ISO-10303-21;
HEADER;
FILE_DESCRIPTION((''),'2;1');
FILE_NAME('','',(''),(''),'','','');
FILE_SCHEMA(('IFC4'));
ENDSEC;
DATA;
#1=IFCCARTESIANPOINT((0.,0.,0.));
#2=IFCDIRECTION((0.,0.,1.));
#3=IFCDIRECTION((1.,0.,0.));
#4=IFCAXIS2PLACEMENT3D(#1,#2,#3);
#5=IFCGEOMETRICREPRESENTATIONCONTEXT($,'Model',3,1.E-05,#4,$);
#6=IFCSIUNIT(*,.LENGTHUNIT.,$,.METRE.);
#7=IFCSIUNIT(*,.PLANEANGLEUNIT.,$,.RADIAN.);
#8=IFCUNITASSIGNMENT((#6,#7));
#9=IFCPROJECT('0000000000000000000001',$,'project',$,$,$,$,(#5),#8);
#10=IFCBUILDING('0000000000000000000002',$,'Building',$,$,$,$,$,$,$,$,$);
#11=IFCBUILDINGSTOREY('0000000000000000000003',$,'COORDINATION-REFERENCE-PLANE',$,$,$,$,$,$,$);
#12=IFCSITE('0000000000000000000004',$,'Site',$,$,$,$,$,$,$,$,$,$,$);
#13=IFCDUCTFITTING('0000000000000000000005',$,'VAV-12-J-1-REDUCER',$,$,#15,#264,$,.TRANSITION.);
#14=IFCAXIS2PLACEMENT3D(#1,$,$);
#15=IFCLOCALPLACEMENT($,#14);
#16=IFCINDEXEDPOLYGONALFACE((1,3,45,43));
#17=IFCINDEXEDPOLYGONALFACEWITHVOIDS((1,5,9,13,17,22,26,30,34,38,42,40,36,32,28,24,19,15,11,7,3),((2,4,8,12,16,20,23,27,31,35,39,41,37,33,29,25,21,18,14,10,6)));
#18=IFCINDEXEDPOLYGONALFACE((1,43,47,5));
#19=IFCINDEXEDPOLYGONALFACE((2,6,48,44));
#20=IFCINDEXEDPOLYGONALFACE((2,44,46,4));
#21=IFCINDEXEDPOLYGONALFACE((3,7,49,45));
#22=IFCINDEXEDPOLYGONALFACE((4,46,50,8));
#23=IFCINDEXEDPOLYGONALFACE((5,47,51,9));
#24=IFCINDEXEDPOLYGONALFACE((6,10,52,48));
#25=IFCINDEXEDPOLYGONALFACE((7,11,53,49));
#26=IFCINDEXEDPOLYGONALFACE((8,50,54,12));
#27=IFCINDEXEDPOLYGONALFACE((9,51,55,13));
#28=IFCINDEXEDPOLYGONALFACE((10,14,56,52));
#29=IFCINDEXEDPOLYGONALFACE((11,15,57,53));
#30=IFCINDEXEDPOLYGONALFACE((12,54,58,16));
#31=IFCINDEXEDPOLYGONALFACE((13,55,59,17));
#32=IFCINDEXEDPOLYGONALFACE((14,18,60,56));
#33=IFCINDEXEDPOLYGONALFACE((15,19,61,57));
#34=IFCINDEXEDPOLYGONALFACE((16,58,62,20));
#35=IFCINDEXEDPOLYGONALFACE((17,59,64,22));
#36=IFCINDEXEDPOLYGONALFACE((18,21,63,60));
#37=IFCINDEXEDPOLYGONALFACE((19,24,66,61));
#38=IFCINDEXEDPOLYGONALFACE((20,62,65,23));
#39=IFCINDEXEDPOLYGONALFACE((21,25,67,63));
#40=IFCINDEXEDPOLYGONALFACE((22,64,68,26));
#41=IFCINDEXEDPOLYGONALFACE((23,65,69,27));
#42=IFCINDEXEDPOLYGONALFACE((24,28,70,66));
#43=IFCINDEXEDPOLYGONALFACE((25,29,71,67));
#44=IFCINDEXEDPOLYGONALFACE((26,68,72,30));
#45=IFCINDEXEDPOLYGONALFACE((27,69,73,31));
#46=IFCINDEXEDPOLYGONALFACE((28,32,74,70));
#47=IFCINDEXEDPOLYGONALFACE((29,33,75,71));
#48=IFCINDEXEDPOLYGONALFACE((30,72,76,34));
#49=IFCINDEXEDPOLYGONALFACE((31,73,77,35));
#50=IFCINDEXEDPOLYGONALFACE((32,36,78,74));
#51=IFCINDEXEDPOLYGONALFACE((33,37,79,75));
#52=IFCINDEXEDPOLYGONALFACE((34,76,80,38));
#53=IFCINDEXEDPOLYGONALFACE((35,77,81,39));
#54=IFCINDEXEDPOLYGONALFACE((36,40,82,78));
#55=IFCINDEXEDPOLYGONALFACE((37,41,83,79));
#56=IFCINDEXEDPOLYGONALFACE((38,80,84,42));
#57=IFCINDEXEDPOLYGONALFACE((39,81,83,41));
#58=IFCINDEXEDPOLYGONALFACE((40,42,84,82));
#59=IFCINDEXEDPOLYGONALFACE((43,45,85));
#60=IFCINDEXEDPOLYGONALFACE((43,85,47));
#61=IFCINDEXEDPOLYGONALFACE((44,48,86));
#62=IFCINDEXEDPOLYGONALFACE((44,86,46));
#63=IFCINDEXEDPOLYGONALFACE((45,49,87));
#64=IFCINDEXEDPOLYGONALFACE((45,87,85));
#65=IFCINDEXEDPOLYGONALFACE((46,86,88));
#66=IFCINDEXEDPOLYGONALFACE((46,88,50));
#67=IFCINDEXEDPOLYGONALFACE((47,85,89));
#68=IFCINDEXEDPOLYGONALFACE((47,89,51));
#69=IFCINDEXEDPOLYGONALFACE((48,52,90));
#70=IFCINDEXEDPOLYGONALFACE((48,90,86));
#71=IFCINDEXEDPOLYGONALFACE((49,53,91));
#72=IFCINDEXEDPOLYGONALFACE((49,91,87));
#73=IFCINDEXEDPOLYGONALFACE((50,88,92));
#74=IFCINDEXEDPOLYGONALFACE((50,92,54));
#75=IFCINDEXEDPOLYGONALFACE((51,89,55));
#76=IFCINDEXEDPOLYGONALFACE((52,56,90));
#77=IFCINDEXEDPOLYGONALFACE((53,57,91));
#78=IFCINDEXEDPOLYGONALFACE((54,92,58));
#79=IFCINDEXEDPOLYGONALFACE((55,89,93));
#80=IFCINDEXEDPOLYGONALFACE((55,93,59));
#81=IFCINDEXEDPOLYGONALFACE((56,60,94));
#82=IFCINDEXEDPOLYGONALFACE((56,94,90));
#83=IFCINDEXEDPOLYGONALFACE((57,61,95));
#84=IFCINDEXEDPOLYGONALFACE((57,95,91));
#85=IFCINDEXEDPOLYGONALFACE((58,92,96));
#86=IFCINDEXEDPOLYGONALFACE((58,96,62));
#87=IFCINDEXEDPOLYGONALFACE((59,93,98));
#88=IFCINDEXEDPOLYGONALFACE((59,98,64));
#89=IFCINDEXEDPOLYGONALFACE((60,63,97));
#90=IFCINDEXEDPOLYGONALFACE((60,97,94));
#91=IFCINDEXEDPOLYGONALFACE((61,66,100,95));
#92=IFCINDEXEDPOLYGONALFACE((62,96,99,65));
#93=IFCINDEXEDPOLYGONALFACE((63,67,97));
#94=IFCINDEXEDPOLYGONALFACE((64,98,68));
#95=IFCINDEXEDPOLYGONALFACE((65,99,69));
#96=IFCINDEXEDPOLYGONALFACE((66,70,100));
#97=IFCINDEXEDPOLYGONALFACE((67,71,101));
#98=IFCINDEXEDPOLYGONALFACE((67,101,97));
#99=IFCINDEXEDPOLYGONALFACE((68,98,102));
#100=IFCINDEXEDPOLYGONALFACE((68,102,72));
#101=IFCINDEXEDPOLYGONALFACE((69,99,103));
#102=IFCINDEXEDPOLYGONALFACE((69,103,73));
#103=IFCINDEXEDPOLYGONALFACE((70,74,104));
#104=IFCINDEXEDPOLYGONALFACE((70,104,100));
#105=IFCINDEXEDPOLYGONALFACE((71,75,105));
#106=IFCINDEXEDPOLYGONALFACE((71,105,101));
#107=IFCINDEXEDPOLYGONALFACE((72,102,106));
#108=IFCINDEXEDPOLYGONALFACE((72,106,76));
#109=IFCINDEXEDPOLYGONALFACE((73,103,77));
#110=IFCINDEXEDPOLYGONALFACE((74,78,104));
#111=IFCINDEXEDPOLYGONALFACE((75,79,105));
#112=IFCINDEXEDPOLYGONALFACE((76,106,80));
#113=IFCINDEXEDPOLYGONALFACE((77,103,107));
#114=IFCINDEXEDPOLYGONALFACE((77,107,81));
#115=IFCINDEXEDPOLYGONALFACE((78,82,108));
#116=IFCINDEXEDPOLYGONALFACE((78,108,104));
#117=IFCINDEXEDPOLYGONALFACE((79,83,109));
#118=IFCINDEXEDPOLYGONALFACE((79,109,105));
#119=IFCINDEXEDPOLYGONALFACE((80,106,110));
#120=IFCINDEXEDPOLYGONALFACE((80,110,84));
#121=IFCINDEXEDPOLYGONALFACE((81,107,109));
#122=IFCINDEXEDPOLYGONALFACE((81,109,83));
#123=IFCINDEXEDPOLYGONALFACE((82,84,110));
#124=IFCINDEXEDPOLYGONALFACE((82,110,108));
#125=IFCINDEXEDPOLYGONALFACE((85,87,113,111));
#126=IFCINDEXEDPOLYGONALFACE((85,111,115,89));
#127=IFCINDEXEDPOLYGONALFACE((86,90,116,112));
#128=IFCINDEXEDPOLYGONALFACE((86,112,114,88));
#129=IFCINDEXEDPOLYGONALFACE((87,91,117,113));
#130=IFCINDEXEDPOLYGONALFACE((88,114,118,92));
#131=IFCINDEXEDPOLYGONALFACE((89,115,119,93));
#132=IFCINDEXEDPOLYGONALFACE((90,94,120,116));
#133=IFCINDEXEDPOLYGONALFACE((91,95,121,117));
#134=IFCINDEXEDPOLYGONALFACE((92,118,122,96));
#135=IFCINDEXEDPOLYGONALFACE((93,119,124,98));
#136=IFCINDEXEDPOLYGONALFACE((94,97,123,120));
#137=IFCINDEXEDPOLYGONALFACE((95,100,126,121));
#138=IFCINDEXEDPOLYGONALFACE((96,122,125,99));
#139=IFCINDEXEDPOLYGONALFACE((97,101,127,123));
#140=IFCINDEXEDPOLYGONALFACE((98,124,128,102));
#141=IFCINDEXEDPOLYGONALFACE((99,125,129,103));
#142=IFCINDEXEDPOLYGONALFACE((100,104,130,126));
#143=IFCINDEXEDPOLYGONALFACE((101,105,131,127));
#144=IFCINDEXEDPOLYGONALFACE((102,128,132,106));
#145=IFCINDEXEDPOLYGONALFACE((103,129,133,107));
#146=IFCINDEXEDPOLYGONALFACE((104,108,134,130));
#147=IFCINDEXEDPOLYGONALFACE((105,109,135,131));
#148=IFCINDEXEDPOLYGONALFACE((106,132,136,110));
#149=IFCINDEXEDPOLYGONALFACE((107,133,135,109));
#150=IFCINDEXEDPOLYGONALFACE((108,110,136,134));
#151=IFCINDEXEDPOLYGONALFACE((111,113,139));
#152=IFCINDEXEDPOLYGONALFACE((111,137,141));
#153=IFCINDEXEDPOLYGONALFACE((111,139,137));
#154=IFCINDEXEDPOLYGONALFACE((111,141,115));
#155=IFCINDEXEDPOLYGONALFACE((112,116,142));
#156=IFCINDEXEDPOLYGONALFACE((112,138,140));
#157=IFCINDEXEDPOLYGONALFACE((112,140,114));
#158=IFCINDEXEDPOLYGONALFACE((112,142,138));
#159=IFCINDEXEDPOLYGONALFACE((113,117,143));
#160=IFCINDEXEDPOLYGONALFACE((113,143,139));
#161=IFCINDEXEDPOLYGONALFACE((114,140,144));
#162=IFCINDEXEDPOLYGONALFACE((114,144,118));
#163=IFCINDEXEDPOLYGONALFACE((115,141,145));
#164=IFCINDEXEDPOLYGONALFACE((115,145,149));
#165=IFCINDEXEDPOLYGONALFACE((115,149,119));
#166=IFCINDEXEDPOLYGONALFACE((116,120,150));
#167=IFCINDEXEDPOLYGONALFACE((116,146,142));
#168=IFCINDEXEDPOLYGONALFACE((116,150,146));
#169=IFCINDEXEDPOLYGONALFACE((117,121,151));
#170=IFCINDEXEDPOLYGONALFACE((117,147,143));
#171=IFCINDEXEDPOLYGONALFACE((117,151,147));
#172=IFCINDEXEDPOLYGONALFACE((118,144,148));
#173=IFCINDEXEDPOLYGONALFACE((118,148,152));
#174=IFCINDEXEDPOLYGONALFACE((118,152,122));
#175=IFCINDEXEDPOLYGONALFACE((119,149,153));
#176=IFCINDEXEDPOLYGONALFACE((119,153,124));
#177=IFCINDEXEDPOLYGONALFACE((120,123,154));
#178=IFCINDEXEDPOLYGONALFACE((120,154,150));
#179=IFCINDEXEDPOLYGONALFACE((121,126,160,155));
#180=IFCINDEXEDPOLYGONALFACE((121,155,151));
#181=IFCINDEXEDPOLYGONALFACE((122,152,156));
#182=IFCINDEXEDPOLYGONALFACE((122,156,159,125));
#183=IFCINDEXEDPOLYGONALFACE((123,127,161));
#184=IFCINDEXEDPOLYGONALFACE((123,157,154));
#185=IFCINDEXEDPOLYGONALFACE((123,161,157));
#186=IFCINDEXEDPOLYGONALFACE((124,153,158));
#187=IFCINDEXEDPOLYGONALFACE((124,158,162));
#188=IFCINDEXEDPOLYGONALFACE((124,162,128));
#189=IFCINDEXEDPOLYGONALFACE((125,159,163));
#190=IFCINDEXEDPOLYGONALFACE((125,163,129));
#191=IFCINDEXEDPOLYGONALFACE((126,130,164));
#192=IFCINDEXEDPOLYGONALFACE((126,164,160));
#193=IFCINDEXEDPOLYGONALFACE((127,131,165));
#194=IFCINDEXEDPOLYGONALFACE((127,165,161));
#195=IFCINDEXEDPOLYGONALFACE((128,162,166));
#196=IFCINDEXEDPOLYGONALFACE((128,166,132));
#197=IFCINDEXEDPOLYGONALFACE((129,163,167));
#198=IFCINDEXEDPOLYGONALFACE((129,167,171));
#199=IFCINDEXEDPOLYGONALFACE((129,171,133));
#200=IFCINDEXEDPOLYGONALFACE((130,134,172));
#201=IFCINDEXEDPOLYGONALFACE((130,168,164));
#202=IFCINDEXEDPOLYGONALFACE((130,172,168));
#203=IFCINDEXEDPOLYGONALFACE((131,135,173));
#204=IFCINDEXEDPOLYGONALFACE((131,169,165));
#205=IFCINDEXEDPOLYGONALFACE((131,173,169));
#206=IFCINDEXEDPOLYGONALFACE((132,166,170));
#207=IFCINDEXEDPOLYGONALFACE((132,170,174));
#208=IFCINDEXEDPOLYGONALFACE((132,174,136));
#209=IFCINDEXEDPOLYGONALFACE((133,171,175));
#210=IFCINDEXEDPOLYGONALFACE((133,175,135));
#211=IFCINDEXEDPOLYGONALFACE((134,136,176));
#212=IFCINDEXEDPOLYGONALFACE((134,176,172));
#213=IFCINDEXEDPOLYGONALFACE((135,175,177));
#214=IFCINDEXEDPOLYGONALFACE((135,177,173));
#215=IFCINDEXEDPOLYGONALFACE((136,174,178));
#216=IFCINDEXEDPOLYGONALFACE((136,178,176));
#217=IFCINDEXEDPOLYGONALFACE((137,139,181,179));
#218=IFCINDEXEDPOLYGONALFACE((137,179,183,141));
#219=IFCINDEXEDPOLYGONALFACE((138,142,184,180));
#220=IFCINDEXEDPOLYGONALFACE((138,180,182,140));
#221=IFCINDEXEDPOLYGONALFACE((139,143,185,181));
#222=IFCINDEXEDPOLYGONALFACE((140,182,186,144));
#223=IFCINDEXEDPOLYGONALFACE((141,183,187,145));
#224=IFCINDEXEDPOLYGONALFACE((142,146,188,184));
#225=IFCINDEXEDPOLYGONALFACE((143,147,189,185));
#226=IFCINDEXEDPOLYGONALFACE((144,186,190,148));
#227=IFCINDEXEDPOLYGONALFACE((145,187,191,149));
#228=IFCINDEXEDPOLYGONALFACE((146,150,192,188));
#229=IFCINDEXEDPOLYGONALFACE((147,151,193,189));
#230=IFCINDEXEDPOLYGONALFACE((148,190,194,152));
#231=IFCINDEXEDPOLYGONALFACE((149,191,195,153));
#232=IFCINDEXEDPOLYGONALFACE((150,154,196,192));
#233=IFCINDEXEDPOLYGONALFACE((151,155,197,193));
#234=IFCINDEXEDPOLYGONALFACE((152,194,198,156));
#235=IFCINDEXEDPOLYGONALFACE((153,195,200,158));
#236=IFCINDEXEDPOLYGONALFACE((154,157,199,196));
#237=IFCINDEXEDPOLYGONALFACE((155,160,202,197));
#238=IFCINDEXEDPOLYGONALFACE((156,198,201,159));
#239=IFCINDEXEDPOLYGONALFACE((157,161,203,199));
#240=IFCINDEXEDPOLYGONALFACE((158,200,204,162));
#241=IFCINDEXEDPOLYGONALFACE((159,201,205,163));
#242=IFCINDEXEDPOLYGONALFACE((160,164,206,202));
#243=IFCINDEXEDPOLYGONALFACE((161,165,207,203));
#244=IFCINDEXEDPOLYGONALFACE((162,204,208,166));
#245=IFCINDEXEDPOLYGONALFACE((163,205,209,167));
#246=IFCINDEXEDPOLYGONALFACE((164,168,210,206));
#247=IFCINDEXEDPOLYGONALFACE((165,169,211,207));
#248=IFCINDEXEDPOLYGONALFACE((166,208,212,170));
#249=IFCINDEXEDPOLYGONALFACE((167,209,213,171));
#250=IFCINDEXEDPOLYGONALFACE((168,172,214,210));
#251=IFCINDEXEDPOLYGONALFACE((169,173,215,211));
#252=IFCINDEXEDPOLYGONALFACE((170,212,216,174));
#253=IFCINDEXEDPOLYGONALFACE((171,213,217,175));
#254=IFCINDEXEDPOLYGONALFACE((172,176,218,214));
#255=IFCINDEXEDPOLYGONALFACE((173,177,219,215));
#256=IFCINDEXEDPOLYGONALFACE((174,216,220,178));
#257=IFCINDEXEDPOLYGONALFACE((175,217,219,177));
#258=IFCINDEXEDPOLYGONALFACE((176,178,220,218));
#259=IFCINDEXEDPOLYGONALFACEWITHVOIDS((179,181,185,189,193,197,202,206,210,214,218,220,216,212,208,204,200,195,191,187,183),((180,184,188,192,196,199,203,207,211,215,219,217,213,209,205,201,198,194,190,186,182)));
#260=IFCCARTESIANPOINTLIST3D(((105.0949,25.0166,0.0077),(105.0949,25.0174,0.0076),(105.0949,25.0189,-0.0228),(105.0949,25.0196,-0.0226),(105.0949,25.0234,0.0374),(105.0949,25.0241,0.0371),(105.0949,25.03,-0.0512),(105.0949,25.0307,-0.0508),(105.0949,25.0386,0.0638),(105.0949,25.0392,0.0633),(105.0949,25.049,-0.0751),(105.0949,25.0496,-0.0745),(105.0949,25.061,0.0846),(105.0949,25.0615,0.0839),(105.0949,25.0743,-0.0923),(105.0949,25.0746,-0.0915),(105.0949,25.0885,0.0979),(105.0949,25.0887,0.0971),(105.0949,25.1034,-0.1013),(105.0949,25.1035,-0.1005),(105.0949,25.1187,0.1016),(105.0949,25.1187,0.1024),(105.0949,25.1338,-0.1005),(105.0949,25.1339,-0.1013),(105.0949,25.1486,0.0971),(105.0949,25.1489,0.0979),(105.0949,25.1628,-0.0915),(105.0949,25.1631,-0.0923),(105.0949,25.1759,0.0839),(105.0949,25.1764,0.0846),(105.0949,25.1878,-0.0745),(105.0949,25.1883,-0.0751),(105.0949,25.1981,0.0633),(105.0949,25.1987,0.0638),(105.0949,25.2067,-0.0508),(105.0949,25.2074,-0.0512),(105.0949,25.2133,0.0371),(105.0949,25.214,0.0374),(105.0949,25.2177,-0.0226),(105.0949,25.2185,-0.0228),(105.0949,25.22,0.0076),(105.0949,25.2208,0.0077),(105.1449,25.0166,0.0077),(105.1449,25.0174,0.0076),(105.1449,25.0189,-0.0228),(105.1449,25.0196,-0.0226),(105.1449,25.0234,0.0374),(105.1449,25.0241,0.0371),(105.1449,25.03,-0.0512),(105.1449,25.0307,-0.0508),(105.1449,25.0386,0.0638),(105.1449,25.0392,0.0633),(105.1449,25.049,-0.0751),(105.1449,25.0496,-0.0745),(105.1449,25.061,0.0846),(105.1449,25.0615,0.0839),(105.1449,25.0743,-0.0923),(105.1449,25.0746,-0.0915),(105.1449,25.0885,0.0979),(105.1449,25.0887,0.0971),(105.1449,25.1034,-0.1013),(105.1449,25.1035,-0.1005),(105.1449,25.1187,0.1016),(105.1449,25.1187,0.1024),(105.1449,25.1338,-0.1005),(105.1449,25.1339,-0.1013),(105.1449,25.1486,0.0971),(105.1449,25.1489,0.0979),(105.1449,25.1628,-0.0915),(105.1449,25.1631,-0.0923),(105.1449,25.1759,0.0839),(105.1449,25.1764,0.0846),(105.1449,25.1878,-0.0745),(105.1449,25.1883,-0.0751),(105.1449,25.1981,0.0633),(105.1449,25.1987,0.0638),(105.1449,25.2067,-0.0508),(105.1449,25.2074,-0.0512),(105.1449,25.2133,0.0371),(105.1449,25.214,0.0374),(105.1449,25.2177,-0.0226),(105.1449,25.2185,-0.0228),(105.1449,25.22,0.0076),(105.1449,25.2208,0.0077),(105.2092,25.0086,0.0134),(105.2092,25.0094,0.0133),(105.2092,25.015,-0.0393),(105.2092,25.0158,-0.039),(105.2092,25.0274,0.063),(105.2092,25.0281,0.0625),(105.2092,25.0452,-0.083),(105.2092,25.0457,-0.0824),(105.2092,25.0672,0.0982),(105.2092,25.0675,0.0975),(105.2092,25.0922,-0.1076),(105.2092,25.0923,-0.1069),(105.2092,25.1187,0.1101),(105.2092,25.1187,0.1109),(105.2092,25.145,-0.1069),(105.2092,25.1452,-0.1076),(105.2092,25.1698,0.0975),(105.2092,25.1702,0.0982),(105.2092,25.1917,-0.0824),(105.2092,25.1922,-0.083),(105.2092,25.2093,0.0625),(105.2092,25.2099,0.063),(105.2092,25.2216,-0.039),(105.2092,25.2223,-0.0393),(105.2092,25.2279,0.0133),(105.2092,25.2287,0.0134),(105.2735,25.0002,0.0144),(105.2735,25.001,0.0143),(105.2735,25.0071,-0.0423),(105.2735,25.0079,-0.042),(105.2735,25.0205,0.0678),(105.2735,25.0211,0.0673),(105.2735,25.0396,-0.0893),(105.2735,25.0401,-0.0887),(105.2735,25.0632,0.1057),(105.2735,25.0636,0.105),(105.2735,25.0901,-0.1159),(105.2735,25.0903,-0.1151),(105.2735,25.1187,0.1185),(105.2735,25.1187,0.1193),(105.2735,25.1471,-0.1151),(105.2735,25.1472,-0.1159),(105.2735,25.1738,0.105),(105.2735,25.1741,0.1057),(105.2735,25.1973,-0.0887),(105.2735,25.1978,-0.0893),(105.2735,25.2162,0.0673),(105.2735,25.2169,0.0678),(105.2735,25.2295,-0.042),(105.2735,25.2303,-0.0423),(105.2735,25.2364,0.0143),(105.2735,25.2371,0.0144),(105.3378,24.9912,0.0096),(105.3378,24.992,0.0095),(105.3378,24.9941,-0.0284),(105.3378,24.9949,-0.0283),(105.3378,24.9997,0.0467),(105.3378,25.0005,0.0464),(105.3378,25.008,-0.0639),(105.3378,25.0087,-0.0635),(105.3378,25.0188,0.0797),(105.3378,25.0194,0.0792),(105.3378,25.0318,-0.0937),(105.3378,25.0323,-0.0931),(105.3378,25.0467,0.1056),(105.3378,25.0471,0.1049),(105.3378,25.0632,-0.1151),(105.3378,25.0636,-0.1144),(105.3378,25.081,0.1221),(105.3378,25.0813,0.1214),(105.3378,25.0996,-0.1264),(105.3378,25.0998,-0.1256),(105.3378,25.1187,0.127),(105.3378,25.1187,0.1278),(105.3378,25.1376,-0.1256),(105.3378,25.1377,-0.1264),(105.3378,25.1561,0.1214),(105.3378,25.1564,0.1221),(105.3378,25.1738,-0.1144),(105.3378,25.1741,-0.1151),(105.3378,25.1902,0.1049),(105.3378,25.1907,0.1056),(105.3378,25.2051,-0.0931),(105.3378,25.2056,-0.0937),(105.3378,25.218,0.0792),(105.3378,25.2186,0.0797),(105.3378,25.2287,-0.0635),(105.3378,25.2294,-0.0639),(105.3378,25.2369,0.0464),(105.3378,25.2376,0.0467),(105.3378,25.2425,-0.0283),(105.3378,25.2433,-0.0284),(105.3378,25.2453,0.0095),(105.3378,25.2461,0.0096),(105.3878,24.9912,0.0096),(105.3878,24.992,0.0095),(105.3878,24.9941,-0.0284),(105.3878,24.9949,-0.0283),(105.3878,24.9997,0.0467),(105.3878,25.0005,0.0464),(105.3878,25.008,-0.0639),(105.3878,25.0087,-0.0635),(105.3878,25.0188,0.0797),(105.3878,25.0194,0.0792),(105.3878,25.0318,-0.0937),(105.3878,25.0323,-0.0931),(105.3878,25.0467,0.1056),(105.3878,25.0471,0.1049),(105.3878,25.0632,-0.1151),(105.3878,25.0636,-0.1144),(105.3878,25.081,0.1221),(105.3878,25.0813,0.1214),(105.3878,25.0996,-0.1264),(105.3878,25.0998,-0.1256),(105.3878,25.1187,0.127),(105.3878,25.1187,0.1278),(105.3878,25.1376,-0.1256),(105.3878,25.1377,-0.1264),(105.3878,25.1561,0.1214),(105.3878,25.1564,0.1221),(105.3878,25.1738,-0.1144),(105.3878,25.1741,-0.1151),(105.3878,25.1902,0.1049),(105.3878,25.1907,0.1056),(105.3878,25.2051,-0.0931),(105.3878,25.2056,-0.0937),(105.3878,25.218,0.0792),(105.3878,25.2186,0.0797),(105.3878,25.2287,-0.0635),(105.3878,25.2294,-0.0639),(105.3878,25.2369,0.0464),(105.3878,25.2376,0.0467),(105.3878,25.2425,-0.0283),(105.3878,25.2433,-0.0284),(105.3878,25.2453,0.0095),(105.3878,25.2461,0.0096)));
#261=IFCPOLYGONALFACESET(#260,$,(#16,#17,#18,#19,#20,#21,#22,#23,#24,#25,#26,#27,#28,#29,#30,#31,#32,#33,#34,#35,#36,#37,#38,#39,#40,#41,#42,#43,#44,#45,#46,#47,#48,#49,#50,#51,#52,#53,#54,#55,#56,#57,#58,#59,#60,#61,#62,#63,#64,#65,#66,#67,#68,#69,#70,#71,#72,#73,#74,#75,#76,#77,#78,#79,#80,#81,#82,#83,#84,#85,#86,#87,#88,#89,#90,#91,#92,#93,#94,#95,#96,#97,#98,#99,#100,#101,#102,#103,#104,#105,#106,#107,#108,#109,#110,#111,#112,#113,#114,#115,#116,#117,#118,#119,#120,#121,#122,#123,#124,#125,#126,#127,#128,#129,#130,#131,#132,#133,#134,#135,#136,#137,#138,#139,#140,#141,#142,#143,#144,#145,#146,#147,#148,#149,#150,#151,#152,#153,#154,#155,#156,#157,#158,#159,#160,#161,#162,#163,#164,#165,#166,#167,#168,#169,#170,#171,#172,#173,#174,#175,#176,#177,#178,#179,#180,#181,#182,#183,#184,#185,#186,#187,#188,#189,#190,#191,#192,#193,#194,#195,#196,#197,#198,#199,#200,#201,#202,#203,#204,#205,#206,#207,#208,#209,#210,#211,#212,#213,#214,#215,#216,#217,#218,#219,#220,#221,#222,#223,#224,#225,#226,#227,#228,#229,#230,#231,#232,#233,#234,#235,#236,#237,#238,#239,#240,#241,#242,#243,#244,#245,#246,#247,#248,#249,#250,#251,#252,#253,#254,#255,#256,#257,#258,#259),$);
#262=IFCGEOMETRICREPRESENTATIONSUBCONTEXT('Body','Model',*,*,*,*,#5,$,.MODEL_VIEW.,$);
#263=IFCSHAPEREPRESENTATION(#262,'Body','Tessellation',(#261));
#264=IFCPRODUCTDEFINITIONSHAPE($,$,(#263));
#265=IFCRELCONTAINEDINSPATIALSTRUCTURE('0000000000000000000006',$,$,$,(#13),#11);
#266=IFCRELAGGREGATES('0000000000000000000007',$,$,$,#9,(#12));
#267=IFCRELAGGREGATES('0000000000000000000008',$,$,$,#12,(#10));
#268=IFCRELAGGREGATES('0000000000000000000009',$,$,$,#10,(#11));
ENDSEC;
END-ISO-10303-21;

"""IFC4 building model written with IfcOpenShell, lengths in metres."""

from ifc_helpers import new_model, entity, si_unit, frame, origin_with_axes, place, context, subcontext, project, spatial, element, save


model = new_model("IFC4")

# Units and contexts
model_context = context("Model", 3, precision=1e-05, world=origin_with_axes())
body_context_1 = subcontext(model_context, "Body", "Model", "MODEL_VIEW")
ifc_project = project(units=[si_unit("LENGTHUNIT", "METRE"), si_unit("PLANEANGLEUNIT", "RADIAN")], contexts=[model_context])

# Site, building, storey
site = spatial("IfcSite", under=ifc_project, Name="Site")
building = spatial("IfcBuilding", under=site, Name="Building")
storey = spatial("IfcBuildingStorey", under=building, Name="COORDINATION-REFERENCE-PLANE")

# Duct fitting
for number, where, z_axis, x_axis, name in (
    (1, (105.3878, 25.1187, 0.0), (0.0, -1.0, 0.0), (0.0, 0.0, 1.0), "VAV-12-J-1-REDUCER"),
):
    element("IfcDuctFitting", number, at=place(None, frame(where, z_axis=z_axis, x_axis=x_axis)), inside=storey, Name=name, PredefinedType="TRANSITION", context=body_context_1, shape_type="SweptSolid", body=[
        entity("IfcRevolvedAreaSolid", entity("IfcArbitraryClosedProfileDef", "AREA", None, entity("IfcPolyline", [entity("IfcCartesianPoint", [0.1278, 0.0]), entity("IfcCartesianPoint", [0.1278, 0.05]), entity("IfcCartesianPoint", [0.1024, 0.2429]), entity("IfcCartesianPoint", [0.1024, 0.2929]), entity("IfcCartesianPoint", [0.1016, 0.2929]), entity("IfcCartesianPoint", [0.1016, 0.2429]), entity("IfcCartesianPoint", [0.127, 0.05]), entity("IfcCartesianPoint", [0.127, 0.0]), entity("IfcCartesianPoint", [0.1278, 0.0])])), entity("IfcAxis2Placement3D", entity("IfcCartesianPoint", [0.0, 0.0, 0.0])), entity("IfcAxis1Placement", entity("IfcCartesianPoint", [0.0, 0.0, 0.0]), entity("IfcDirection", [0.0, 1.0, 0.0])), 6.283185),
    ])

save(model, "model.ifc")
